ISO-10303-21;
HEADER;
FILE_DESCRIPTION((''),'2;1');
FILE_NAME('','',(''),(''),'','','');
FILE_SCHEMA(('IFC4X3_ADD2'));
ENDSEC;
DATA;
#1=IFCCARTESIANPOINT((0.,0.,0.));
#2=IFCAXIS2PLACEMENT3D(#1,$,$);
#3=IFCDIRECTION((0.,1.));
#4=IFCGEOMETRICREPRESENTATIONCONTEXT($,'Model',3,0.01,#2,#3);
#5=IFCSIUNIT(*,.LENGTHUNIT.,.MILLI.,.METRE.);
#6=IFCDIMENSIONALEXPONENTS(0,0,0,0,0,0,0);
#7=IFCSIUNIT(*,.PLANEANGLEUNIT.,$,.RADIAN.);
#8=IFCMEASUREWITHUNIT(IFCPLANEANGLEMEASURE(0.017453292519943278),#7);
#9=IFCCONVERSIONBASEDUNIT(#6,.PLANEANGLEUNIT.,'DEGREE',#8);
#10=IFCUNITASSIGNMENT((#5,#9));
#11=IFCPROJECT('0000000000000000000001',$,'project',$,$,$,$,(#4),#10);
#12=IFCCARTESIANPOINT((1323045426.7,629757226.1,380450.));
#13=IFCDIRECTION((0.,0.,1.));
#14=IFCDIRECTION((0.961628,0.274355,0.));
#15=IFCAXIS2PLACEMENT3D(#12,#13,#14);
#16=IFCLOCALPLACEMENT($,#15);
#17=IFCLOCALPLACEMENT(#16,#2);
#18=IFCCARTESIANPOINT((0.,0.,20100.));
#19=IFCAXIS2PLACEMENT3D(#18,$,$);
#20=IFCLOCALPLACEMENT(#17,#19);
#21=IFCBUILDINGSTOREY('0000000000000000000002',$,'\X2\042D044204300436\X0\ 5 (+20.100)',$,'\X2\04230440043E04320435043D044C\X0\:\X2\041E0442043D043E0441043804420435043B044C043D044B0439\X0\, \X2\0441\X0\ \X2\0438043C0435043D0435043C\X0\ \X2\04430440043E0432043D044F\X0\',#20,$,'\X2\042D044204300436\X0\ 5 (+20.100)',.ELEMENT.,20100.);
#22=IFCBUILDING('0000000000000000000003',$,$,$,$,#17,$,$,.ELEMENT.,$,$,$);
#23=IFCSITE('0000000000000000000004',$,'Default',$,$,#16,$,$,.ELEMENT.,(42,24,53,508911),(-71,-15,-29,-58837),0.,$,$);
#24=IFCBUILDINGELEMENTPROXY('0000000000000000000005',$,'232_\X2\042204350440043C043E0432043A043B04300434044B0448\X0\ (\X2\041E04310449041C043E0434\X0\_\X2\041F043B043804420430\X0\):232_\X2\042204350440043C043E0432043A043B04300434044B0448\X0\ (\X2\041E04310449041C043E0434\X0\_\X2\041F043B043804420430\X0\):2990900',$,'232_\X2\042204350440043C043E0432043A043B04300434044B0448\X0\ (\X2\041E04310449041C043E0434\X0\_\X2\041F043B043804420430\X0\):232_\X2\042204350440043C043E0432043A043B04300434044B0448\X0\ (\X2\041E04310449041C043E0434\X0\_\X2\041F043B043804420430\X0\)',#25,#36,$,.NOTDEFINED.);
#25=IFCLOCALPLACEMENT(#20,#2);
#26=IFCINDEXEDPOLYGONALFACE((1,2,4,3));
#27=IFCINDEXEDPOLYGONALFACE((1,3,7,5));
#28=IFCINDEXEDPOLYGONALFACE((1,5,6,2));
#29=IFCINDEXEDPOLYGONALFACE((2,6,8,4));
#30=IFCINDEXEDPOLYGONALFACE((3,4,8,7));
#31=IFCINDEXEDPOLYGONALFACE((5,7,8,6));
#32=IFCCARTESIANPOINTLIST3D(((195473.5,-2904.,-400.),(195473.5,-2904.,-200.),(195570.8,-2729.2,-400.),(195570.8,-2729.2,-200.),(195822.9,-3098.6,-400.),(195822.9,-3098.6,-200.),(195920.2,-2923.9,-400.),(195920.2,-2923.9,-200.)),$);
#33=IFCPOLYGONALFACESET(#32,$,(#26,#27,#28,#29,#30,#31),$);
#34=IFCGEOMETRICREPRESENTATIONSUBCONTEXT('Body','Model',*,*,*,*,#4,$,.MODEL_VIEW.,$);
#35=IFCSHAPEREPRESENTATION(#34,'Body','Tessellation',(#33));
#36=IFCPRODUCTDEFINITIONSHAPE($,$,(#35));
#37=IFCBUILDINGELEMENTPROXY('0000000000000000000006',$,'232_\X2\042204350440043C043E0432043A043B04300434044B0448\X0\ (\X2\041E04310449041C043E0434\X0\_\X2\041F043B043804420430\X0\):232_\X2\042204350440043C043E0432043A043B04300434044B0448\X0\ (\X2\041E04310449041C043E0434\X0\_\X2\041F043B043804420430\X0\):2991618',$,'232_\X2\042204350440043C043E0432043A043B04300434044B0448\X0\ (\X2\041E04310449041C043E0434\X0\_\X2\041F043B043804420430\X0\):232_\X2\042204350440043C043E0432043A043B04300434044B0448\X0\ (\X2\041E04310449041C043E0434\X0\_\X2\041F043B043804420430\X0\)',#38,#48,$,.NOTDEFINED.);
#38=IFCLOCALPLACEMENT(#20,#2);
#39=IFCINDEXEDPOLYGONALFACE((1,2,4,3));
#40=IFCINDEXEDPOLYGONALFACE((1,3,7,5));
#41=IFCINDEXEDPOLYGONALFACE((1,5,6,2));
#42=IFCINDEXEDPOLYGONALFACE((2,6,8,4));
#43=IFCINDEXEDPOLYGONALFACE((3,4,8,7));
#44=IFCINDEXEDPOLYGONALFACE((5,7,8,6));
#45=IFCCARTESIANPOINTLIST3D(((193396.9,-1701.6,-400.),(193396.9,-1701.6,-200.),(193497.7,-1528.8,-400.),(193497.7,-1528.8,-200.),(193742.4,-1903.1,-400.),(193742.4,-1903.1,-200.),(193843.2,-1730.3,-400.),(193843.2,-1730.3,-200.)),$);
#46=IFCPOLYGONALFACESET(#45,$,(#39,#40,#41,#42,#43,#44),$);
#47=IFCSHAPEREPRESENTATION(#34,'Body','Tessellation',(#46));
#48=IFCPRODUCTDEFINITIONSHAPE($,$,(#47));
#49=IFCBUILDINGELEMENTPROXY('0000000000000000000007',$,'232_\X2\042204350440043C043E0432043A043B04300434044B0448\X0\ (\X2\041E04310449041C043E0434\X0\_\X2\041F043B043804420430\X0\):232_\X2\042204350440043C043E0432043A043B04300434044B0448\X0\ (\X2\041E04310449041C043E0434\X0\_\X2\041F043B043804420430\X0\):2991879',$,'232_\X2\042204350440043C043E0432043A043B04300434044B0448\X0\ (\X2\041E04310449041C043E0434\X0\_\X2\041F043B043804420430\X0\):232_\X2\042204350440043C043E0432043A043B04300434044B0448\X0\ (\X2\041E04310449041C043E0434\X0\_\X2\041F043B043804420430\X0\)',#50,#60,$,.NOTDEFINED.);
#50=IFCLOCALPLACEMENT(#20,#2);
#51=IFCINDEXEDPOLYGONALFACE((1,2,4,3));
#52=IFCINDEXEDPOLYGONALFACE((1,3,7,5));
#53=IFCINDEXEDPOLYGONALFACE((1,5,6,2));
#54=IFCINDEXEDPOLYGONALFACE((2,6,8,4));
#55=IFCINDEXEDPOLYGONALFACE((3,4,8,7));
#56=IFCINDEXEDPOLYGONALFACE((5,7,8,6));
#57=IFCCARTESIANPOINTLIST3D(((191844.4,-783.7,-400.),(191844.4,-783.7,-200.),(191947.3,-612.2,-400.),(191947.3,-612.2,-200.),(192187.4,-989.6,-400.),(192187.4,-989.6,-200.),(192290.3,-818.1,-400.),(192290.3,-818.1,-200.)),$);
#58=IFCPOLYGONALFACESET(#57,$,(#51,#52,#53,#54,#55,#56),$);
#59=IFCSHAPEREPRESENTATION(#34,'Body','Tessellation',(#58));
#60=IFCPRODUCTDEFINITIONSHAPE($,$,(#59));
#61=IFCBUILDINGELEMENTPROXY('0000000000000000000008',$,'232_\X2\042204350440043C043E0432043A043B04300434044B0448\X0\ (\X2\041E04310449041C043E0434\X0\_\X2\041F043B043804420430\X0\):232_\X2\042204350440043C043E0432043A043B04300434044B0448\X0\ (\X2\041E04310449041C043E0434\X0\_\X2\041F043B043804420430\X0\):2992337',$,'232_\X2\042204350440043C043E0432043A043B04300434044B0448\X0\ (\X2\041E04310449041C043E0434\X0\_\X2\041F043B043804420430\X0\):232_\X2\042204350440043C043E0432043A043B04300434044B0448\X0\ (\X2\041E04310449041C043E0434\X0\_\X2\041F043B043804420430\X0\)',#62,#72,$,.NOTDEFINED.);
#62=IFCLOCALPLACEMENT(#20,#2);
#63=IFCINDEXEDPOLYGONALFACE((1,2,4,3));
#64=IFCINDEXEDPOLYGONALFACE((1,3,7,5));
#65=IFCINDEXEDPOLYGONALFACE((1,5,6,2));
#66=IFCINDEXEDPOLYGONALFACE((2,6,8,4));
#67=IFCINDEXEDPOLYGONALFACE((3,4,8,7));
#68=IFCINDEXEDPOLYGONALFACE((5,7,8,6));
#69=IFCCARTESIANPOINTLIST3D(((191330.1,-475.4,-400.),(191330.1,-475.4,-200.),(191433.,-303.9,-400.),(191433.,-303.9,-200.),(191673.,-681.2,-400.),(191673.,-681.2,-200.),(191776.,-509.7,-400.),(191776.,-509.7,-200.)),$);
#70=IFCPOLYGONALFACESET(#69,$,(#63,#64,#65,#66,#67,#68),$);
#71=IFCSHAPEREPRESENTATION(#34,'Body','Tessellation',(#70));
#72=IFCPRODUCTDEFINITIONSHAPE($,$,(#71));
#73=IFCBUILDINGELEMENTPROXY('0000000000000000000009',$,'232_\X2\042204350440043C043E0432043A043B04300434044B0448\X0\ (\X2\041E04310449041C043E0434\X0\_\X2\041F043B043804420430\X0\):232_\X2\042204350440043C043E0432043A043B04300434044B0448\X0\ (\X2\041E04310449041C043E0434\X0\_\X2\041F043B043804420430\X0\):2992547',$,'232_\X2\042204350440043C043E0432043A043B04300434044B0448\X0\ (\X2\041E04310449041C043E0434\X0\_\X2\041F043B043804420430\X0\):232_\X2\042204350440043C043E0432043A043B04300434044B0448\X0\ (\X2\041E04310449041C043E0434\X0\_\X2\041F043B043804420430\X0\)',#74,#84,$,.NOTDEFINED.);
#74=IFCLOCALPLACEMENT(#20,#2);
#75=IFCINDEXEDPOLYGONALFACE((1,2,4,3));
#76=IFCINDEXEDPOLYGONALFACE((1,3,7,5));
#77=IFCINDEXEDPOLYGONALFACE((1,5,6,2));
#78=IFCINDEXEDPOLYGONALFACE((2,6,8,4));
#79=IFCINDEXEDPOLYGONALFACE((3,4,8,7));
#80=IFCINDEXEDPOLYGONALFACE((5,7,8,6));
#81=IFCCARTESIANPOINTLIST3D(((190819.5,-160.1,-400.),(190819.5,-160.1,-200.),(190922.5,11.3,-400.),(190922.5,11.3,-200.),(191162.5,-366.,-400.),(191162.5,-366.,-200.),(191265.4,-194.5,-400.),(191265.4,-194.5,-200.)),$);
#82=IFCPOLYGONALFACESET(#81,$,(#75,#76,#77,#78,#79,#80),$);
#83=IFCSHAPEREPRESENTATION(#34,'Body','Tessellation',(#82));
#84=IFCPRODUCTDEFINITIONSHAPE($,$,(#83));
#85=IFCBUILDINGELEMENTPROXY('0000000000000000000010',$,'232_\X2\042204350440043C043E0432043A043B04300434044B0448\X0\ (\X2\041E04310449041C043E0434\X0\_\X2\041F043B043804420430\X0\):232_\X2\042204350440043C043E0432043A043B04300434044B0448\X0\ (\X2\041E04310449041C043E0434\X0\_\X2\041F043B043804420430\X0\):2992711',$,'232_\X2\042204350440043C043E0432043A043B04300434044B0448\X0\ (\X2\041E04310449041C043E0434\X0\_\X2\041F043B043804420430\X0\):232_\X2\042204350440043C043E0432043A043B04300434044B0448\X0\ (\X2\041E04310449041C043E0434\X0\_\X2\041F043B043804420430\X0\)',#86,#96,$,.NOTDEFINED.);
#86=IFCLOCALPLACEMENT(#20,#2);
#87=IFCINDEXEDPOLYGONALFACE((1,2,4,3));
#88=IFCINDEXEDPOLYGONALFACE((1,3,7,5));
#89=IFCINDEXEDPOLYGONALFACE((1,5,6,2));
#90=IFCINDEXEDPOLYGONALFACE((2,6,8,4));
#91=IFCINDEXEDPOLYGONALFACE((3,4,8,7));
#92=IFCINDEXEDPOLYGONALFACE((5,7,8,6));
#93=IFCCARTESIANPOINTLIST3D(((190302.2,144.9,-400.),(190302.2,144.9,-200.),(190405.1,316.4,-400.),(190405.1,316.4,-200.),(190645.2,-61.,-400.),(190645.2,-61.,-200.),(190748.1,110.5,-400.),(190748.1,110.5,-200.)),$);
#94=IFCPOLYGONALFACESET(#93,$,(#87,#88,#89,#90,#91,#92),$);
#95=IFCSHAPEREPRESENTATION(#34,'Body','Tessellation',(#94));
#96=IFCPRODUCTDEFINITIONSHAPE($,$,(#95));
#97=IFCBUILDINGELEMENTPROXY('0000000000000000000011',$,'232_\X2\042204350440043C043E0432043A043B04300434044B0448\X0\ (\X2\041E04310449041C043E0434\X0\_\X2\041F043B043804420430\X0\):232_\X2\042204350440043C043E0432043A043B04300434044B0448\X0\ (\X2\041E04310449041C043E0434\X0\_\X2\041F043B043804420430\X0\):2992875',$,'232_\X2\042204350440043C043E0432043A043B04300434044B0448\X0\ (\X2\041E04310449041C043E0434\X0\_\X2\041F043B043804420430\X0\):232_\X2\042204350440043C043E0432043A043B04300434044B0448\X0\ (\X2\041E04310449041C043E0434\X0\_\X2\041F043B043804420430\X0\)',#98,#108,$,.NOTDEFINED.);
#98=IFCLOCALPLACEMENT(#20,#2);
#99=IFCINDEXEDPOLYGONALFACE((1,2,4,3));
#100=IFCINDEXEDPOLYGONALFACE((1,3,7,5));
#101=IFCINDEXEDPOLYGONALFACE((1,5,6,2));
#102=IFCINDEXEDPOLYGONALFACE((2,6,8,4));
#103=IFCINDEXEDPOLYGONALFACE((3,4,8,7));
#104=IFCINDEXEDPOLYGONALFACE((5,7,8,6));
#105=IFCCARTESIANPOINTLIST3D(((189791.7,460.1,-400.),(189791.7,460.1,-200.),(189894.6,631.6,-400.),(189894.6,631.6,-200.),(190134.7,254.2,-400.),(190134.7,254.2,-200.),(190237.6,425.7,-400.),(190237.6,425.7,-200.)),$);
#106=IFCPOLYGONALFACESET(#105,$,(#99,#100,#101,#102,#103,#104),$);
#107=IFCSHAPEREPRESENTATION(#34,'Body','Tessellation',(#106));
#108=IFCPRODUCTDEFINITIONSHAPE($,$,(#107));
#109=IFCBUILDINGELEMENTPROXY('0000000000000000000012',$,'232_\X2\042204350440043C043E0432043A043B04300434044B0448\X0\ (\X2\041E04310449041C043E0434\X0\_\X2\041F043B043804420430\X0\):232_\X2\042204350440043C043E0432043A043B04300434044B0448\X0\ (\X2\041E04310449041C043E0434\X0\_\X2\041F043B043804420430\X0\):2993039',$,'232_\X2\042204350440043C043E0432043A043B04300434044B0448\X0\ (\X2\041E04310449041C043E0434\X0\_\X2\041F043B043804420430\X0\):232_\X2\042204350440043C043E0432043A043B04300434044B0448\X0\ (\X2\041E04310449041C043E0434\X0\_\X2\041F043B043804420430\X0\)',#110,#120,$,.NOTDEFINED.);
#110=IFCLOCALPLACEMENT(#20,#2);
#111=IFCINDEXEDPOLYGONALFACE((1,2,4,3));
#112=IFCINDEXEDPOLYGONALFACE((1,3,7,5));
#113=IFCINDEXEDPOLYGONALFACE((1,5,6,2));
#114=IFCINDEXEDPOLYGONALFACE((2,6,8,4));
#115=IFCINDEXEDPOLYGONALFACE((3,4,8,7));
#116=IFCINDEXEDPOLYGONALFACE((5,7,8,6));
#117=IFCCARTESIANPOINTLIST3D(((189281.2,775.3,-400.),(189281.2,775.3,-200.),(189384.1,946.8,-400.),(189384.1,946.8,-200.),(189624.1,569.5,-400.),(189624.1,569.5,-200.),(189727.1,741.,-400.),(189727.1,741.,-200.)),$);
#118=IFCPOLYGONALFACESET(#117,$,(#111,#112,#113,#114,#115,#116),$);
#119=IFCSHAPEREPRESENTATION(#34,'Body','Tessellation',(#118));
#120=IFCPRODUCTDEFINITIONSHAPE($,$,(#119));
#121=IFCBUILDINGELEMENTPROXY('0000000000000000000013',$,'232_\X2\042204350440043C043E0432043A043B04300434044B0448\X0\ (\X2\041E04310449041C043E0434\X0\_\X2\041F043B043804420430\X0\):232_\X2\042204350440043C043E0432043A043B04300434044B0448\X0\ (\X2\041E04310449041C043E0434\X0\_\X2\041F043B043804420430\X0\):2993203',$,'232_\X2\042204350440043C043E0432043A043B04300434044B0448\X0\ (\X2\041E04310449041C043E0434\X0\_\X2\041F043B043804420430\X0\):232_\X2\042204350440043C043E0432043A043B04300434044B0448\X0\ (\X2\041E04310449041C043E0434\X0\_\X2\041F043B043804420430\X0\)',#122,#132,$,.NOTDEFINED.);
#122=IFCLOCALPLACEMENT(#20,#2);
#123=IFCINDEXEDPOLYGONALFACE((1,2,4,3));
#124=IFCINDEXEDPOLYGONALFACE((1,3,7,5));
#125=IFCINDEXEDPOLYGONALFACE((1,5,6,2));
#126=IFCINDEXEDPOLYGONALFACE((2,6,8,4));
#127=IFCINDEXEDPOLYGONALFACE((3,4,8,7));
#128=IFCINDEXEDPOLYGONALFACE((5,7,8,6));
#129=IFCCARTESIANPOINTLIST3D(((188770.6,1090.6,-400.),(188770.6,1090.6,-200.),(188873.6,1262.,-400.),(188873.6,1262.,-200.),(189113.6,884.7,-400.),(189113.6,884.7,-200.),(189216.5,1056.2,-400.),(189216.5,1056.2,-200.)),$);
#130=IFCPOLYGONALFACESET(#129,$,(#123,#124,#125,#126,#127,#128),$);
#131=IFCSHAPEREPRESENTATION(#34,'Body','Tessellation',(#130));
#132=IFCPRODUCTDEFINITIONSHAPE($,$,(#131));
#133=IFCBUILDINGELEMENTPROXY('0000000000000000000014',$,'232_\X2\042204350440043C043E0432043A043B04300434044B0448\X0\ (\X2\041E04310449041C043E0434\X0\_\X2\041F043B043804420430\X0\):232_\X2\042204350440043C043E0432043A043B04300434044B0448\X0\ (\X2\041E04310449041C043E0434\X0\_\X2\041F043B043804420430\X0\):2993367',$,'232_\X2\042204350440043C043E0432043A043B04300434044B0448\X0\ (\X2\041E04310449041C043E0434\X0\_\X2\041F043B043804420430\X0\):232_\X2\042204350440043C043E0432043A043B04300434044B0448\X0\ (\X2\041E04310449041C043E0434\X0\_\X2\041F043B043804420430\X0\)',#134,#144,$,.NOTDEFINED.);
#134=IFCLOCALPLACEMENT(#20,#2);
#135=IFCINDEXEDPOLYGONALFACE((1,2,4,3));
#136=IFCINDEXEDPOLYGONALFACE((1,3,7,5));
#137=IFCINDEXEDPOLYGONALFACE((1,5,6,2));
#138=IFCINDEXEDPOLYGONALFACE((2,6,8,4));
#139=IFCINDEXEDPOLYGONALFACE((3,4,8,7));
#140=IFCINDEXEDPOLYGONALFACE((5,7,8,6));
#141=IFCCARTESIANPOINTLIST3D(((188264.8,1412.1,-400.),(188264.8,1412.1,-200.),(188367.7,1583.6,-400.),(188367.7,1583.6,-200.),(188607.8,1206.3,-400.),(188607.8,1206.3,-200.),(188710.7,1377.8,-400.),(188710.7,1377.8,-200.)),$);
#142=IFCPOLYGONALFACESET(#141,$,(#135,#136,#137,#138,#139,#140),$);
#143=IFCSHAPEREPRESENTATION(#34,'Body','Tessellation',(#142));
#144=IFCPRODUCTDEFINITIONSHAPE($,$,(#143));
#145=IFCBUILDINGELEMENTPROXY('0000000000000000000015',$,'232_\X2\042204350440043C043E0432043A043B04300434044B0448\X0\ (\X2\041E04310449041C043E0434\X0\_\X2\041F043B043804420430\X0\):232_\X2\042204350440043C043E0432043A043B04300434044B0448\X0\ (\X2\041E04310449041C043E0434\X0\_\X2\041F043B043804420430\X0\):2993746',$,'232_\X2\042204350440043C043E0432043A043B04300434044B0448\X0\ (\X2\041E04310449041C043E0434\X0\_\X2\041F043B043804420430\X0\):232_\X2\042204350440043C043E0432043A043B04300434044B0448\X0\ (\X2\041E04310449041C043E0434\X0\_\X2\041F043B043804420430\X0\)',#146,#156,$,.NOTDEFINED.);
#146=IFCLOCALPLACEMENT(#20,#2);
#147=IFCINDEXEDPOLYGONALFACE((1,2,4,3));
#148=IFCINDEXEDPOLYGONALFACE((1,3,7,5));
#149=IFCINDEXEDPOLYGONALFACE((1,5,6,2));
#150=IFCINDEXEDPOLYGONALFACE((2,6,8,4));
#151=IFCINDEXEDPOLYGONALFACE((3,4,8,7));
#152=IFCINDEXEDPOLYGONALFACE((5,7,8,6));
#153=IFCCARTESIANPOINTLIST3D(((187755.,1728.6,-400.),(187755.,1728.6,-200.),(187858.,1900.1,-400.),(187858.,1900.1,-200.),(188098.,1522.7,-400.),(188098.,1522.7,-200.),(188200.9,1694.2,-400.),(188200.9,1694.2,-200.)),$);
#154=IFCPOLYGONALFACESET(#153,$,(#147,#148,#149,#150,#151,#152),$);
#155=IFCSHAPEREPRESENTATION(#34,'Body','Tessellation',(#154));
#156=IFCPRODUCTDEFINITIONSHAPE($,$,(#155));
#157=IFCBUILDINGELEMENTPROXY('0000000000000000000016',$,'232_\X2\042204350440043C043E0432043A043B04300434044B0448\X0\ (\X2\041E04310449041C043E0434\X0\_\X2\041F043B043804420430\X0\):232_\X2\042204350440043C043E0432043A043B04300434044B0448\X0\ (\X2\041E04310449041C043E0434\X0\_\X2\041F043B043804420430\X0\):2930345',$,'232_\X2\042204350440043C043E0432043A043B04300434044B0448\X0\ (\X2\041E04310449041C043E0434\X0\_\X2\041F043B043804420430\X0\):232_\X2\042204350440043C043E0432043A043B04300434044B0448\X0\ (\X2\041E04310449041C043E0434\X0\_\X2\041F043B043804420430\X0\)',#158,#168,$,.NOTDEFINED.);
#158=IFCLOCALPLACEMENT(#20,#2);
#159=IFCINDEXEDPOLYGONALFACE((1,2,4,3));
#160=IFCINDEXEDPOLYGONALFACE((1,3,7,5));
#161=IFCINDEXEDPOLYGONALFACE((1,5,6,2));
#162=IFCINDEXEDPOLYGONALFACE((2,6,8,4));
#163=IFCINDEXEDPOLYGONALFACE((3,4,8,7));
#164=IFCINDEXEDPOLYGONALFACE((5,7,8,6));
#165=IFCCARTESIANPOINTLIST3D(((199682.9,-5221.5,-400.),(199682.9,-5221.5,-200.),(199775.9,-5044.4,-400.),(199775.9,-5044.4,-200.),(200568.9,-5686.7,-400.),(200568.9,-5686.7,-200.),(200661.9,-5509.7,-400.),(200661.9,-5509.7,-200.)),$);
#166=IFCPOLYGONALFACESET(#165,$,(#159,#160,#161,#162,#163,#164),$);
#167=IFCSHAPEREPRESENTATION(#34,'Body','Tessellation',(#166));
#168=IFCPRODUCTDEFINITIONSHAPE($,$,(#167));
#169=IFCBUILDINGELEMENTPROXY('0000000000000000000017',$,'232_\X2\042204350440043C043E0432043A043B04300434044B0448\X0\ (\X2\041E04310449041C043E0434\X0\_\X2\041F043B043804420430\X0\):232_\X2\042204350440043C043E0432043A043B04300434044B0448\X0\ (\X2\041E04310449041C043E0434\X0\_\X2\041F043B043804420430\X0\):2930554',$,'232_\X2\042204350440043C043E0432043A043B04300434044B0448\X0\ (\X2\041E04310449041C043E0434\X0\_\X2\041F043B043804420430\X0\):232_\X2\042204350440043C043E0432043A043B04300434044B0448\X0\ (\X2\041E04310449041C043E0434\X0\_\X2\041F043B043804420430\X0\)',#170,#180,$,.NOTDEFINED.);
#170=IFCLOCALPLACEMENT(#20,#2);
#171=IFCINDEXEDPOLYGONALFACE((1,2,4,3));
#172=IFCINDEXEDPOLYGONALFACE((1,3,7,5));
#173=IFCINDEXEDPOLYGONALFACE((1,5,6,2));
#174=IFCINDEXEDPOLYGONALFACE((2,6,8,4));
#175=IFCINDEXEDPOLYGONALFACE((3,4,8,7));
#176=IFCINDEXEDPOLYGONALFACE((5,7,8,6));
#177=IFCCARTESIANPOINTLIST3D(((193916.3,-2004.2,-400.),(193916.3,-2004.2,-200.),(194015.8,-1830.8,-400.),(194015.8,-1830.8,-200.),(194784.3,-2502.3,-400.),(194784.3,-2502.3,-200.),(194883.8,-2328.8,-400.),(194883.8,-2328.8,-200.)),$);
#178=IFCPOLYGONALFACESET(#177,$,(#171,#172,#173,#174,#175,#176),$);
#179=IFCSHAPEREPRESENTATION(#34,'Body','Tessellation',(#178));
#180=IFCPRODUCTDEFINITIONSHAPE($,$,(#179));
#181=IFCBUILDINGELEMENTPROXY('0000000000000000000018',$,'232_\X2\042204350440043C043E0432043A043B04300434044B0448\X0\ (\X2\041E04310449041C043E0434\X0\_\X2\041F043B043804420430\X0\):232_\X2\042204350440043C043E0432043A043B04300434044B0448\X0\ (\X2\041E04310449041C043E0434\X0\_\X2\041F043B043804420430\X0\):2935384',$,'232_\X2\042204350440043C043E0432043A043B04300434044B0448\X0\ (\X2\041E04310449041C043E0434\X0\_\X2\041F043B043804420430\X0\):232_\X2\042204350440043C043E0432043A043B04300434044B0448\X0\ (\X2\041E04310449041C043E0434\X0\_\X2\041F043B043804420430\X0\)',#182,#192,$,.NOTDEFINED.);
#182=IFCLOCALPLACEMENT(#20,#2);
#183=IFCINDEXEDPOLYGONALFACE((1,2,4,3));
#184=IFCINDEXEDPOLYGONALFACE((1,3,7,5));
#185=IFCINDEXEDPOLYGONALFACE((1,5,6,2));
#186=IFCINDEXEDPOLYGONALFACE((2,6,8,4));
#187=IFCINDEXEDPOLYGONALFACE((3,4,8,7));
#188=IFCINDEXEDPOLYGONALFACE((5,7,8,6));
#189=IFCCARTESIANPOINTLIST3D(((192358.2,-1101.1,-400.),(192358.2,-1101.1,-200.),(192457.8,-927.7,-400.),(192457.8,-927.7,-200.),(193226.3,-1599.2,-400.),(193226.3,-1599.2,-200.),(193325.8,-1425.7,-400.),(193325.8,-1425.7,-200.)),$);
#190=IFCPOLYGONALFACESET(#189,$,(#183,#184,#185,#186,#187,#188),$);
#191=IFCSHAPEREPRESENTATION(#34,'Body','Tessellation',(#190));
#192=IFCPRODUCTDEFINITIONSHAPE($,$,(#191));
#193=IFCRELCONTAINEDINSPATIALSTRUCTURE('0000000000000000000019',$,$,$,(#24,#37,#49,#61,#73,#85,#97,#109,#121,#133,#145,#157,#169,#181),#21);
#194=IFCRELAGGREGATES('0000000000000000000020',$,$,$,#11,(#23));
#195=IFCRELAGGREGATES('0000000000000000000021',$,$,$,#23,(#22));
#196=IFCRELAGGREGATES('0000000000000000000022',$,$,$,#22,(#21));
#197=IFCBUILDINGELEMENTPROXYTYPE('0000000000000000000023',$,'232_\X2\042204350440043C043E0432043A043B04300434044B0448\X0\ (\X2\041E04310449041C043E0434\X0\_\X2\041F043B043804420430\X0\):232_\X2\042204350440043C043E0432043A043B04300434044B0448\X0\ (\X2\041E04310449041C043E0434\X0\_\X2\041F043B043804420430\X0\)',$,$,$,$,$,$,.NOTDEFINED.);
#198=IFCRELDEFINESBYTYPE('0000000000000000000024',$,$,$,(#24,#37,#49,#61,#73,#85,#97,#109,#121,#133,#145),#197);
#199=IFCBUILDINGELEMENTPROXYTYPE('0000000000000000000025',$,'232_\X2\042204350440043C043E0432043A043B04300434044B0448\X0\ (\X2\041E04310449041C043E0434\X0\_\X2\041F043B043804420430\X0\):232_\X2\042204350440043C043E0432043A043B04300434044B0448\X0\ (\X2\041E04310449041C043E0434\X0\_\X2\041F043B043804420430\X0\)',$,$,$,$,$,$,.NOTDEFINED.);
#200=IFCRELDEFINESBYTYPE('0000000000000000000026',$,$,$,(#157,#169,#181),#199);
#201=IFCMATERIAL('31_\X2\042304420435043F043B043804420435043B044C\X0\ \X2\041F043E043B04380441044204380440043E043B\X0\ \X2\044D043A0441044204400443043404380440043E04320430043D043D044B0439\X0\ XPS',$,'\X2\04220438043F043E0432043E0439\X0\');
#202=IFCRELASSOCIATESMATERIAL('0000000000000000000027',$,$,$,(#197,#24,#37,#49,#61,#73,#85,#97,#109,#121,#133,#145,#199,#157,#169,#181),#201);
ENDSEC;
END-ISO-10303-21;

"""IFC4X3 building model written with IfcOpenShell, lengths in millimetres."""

from ifc_helpers import new_model, entity, si_unit, converted_unit, direction, frame, origin, origin_2d_with_axis, place, context, subcontext, project, spatial, rectangle, extrude, source, transform, mapped, material, type_object, type_shapes, element, save


model = new_model("IFC4X3")

# Units and contexts
model_context = context("Model", 3, precision=0.01, world=origin(), true_north=direction((0.0, 1.0)))
body_context = subcontext(model_context, "Body", "Model", "MODEL_VIEW")
ifc_project = project(units=[si_unit("LENGTHUNIT", "METRE", prefix="MILLI"), converted_unit("PLANEANGLEUNIT", "DEGREE", entity("IfcPlaneAngleMeasure", 0.017453292519943278), si_unit("PLANEANGLEUNIT", "RADIAN"), dimensions=[0, 0, 0, 0, 0, 0, 0])], contexts=[model_context])

# Site, building, storey
site_placement = place(None, frame((1323045426.7, 629757226.1, 380450.0), z_axis=(0.0, 0.0, 1.0), x_axis=(0.961628, 0.274355, 0.0)))
site = spatial("IfcSite", under=ifc_project, at=site_placement, Name="Default", CompositionType="ELEMENT", RefLatitude=(42, 24, 53, 508911), RefLongitude=(-71, -15, -29, -58837), RefElevation=0.0)
building_placement = place(site_placement, origin())
building = spatial("IfcBuilding", under=site, at=building_placement, CompositionType="ELEMENT")
storey_placement = place(building_placement, frame((0.0, 0.0, 20100.0)))
storey = spatial("IfcBuildingStorey", under=building, at=storey_placement, Name="Этаж 5 (+20.100)", ObjectType="Уровень:Относительный, с именем уровня", LongName="Этаж 5 (+20.100)", CompositionType="ELEMENT", Elevation=20100.0)

# Building element proxies
ifc_material = material(Name="31_Утеплитель Полистирол экструдированный XPS", Category="Типовой")
building_element_proxy_type_1 = type_object("IfcBuildingElementProxyType", Name="232_Термовкладыш (ОбщМод_Плита):232_Термовкладыш (ОбщМод_Плита)", PredefinedType="NOTDEFINED", material=ifc_material)
shared_shape_1 = source(origin(), body_context, "Body", "SweptSolid", [
    extrude(rectangle(XDim=400.0, YDim=200.0, at=origin_2d_with_axis()), frame((200.0, 0.0, -200.0), z_axis=(0.0, 0.0, 1.0), x_axis=(-1.0, 0.0, 0.0)), (0.0, 0.0, 1.0), 200.0),
])
type_shapes(building_element_proxy_type_1, [shared_shape_1])
for number, where, z_axis, x_axis, name in (
    (1, (195871.6, -3011.2, -200.0), (0.0, 0.0, 1.0), (-0.873652, 0.486551, 0.0), "232_Термовкладыш (ОбщМод_Плита):232_Термовкладыш (ОбщМод_Плита):2990900"),
    (2, (193792.8, -1816.7, -200.0), (0.0, 0.0, 1.0), (-0.863801, 0.503832, 0.0), "232_Термовкладыш (ОбщМод_Плита):232_Термовкладыш (ОбщМод_Плита):2991618"),
    (3, (192238.8, -903.8, -200.0), (0.0, 0.0, 1.0), (-0.857413, 0.514629, 0.0), "232_Термовкладыш (ОбщМод_Плита):232_Термовкладыш (ОбщМод_Плита):2991879"),
    (4, (191724.5, -595.5, -200.0), (0.0, 0.0, 1.0), (-0.857413, 0.514629, 0.0), "232_Термовкладыш (ОбщМод_Плита):232_Термовкладыш (ОбщМод_Плита):2992337"),
    (5, (191214.0, -280.2, -200.0), (0.0, 0.0, 1.0), (-0.857413, 0.514629, 0.0), "232_Термовкладыш (ОбщМод_Плита):232_Термовкладыш (ОбщМод_Плита):2992547"),
    (6, (190696.6, 24.8, -200.0), (0.0, 0.0, 1.0), (-0.857413, 0.514629, 0.0), "232_Термовкладыш (ОбщМод_Плита):232_Термовкладыш (ОбщМод_Плита):2992711"),
    (7, (190186.1, 340.0, -200.0), (0.0, 0.0, 1.0), (-0.857413, 0.514629, 0.0), "232_Термовкладыш (ОбщМод_Плита):232_Термовкладыш (ОбщМод_Плита):2992875"),
    (8, (189675.6, 655.2, -200.0), (0.0, 0.0, 1.0), (-0.857413, 0.514629, 0.0), "232_Термовкладыш (ОбщМод_Плита):232_Термовкладыш (ОбщМод_Плита):2993039"),
    (9, (189165.1, 970.4, -200.0), (0.0, 0.0, 1.0), (-0.857413, 0.514629, 0.0), "232_Термовкладыш (ОбщМод_Плита):232_Термовкладыш (ОбщМод_Плита):2993203"),
    (10, (188659.2, 1292.0, -200.0), (0.0, 0.0, 1.0), (-0.857413, 0.514629, 0.0), "232_Термовкладыш (ОбщМод_Плита):232_Термовкладыш (ОбщМод_Плита):2993367"),
    (11, (188149.5, 1608.5, -200.0), (0.0, 0.0, 1.0), (-0.857413, 0.514629, 0.0), "232_Термовкладыш (ОбщМод_Плита):232_Термовкладыш (ОбщМод_Плита):2993746"),
):
    element("IfcBuildingElementProxy", number, at=place(storey_placement, frame(where, z_axis=z_axis, x_axis=x_axis)), inside=storey, type_object=building_element_proxy_type_1, material=ifc_material, Name=name, ObjectType="232_Термовкладыш (ОбщМод_Плита):232_Термовкладыш (ОбщМод_Плита)", PredefinedType="NOTDEFINED", context=body_context, shape_type="MappedRepresentation", body=[
        mapped(shared_shape_1, transform((0.0, 0.0, 0.0), scale=1.0)),
    ])
building_element_proxy_type_2 = type_object("IfcBuildingElementProxyType", Name="232_Термовкладыш (ОбщМод_Плита):232_Термовкладыш (ОбщМод_Плита)", PredefinedType="NOTDEFINED", material=ifc_material)
shared_shape_2 = source(origin(), body_context, "Body", "SweptSolid", [
    extrude(rectangle(XDim=1000.8, YDim=200.0, at=origin_2d_with_axis()), frame((500.4, 0.0, -200.0), z_axis=(0.0, 0.0, 1.0), x_axis=(-1.0, 0.0, 0.0)), (0.0, 0.0, 1.0), 200.0),
])
type_shapes(building_element_proxy_type_2, [shared_shape_2])
for number, where, z_axis, x_axis, name in (
    (12, (200615.4, -5598.2, -200.0), (0.0, 0.0, 1.0), (-0.885382, 0.464865, 0.0), "232_Термовкладыш (ОбщМод_Плита):232_Термовкладыш (ОбщМод_Плита):2930345"),
    (13, (194834.1, -2415.6, -200.0), (0.0, 0.0, 1.0), (-0.867353, 0.497694, 0.0), "232_Термовкладыш (ОбщМод_Плита):232_Термовкладыш (ОбщМод_Плита):2930554"),
    (14, (193276.0, -1512.5, -200.0), (0.0, 0.0, 1.0), (-0.867353, 0.497694, 0.0), "232_Термовкладыш (ОбщМод_Плита):232_Термовкладыш (ОбщМод_Плита):2935384"),
):
    element("IfcBuildingElementProxy", number, at=place(storey_placement, frame(where, z_axis=z_axis, x_axis=x_axis)), inside=storey, type_object=building_element_proxy_type_2, material=ifc_material, Name=name, ObjectType="232_Термовкладыш (ОбщМод_Плита):232_Термовкладыш (ОбщМод_Плита)", PredefinedType="NOTDEFINED", context=body_context, shape_type="MappedRepresentation", body=[
        mapped(shared_shape_2, transform((0.0, 0.0, 0.0), scale=1.0)),
    ])

save(model, "model.ifc")
